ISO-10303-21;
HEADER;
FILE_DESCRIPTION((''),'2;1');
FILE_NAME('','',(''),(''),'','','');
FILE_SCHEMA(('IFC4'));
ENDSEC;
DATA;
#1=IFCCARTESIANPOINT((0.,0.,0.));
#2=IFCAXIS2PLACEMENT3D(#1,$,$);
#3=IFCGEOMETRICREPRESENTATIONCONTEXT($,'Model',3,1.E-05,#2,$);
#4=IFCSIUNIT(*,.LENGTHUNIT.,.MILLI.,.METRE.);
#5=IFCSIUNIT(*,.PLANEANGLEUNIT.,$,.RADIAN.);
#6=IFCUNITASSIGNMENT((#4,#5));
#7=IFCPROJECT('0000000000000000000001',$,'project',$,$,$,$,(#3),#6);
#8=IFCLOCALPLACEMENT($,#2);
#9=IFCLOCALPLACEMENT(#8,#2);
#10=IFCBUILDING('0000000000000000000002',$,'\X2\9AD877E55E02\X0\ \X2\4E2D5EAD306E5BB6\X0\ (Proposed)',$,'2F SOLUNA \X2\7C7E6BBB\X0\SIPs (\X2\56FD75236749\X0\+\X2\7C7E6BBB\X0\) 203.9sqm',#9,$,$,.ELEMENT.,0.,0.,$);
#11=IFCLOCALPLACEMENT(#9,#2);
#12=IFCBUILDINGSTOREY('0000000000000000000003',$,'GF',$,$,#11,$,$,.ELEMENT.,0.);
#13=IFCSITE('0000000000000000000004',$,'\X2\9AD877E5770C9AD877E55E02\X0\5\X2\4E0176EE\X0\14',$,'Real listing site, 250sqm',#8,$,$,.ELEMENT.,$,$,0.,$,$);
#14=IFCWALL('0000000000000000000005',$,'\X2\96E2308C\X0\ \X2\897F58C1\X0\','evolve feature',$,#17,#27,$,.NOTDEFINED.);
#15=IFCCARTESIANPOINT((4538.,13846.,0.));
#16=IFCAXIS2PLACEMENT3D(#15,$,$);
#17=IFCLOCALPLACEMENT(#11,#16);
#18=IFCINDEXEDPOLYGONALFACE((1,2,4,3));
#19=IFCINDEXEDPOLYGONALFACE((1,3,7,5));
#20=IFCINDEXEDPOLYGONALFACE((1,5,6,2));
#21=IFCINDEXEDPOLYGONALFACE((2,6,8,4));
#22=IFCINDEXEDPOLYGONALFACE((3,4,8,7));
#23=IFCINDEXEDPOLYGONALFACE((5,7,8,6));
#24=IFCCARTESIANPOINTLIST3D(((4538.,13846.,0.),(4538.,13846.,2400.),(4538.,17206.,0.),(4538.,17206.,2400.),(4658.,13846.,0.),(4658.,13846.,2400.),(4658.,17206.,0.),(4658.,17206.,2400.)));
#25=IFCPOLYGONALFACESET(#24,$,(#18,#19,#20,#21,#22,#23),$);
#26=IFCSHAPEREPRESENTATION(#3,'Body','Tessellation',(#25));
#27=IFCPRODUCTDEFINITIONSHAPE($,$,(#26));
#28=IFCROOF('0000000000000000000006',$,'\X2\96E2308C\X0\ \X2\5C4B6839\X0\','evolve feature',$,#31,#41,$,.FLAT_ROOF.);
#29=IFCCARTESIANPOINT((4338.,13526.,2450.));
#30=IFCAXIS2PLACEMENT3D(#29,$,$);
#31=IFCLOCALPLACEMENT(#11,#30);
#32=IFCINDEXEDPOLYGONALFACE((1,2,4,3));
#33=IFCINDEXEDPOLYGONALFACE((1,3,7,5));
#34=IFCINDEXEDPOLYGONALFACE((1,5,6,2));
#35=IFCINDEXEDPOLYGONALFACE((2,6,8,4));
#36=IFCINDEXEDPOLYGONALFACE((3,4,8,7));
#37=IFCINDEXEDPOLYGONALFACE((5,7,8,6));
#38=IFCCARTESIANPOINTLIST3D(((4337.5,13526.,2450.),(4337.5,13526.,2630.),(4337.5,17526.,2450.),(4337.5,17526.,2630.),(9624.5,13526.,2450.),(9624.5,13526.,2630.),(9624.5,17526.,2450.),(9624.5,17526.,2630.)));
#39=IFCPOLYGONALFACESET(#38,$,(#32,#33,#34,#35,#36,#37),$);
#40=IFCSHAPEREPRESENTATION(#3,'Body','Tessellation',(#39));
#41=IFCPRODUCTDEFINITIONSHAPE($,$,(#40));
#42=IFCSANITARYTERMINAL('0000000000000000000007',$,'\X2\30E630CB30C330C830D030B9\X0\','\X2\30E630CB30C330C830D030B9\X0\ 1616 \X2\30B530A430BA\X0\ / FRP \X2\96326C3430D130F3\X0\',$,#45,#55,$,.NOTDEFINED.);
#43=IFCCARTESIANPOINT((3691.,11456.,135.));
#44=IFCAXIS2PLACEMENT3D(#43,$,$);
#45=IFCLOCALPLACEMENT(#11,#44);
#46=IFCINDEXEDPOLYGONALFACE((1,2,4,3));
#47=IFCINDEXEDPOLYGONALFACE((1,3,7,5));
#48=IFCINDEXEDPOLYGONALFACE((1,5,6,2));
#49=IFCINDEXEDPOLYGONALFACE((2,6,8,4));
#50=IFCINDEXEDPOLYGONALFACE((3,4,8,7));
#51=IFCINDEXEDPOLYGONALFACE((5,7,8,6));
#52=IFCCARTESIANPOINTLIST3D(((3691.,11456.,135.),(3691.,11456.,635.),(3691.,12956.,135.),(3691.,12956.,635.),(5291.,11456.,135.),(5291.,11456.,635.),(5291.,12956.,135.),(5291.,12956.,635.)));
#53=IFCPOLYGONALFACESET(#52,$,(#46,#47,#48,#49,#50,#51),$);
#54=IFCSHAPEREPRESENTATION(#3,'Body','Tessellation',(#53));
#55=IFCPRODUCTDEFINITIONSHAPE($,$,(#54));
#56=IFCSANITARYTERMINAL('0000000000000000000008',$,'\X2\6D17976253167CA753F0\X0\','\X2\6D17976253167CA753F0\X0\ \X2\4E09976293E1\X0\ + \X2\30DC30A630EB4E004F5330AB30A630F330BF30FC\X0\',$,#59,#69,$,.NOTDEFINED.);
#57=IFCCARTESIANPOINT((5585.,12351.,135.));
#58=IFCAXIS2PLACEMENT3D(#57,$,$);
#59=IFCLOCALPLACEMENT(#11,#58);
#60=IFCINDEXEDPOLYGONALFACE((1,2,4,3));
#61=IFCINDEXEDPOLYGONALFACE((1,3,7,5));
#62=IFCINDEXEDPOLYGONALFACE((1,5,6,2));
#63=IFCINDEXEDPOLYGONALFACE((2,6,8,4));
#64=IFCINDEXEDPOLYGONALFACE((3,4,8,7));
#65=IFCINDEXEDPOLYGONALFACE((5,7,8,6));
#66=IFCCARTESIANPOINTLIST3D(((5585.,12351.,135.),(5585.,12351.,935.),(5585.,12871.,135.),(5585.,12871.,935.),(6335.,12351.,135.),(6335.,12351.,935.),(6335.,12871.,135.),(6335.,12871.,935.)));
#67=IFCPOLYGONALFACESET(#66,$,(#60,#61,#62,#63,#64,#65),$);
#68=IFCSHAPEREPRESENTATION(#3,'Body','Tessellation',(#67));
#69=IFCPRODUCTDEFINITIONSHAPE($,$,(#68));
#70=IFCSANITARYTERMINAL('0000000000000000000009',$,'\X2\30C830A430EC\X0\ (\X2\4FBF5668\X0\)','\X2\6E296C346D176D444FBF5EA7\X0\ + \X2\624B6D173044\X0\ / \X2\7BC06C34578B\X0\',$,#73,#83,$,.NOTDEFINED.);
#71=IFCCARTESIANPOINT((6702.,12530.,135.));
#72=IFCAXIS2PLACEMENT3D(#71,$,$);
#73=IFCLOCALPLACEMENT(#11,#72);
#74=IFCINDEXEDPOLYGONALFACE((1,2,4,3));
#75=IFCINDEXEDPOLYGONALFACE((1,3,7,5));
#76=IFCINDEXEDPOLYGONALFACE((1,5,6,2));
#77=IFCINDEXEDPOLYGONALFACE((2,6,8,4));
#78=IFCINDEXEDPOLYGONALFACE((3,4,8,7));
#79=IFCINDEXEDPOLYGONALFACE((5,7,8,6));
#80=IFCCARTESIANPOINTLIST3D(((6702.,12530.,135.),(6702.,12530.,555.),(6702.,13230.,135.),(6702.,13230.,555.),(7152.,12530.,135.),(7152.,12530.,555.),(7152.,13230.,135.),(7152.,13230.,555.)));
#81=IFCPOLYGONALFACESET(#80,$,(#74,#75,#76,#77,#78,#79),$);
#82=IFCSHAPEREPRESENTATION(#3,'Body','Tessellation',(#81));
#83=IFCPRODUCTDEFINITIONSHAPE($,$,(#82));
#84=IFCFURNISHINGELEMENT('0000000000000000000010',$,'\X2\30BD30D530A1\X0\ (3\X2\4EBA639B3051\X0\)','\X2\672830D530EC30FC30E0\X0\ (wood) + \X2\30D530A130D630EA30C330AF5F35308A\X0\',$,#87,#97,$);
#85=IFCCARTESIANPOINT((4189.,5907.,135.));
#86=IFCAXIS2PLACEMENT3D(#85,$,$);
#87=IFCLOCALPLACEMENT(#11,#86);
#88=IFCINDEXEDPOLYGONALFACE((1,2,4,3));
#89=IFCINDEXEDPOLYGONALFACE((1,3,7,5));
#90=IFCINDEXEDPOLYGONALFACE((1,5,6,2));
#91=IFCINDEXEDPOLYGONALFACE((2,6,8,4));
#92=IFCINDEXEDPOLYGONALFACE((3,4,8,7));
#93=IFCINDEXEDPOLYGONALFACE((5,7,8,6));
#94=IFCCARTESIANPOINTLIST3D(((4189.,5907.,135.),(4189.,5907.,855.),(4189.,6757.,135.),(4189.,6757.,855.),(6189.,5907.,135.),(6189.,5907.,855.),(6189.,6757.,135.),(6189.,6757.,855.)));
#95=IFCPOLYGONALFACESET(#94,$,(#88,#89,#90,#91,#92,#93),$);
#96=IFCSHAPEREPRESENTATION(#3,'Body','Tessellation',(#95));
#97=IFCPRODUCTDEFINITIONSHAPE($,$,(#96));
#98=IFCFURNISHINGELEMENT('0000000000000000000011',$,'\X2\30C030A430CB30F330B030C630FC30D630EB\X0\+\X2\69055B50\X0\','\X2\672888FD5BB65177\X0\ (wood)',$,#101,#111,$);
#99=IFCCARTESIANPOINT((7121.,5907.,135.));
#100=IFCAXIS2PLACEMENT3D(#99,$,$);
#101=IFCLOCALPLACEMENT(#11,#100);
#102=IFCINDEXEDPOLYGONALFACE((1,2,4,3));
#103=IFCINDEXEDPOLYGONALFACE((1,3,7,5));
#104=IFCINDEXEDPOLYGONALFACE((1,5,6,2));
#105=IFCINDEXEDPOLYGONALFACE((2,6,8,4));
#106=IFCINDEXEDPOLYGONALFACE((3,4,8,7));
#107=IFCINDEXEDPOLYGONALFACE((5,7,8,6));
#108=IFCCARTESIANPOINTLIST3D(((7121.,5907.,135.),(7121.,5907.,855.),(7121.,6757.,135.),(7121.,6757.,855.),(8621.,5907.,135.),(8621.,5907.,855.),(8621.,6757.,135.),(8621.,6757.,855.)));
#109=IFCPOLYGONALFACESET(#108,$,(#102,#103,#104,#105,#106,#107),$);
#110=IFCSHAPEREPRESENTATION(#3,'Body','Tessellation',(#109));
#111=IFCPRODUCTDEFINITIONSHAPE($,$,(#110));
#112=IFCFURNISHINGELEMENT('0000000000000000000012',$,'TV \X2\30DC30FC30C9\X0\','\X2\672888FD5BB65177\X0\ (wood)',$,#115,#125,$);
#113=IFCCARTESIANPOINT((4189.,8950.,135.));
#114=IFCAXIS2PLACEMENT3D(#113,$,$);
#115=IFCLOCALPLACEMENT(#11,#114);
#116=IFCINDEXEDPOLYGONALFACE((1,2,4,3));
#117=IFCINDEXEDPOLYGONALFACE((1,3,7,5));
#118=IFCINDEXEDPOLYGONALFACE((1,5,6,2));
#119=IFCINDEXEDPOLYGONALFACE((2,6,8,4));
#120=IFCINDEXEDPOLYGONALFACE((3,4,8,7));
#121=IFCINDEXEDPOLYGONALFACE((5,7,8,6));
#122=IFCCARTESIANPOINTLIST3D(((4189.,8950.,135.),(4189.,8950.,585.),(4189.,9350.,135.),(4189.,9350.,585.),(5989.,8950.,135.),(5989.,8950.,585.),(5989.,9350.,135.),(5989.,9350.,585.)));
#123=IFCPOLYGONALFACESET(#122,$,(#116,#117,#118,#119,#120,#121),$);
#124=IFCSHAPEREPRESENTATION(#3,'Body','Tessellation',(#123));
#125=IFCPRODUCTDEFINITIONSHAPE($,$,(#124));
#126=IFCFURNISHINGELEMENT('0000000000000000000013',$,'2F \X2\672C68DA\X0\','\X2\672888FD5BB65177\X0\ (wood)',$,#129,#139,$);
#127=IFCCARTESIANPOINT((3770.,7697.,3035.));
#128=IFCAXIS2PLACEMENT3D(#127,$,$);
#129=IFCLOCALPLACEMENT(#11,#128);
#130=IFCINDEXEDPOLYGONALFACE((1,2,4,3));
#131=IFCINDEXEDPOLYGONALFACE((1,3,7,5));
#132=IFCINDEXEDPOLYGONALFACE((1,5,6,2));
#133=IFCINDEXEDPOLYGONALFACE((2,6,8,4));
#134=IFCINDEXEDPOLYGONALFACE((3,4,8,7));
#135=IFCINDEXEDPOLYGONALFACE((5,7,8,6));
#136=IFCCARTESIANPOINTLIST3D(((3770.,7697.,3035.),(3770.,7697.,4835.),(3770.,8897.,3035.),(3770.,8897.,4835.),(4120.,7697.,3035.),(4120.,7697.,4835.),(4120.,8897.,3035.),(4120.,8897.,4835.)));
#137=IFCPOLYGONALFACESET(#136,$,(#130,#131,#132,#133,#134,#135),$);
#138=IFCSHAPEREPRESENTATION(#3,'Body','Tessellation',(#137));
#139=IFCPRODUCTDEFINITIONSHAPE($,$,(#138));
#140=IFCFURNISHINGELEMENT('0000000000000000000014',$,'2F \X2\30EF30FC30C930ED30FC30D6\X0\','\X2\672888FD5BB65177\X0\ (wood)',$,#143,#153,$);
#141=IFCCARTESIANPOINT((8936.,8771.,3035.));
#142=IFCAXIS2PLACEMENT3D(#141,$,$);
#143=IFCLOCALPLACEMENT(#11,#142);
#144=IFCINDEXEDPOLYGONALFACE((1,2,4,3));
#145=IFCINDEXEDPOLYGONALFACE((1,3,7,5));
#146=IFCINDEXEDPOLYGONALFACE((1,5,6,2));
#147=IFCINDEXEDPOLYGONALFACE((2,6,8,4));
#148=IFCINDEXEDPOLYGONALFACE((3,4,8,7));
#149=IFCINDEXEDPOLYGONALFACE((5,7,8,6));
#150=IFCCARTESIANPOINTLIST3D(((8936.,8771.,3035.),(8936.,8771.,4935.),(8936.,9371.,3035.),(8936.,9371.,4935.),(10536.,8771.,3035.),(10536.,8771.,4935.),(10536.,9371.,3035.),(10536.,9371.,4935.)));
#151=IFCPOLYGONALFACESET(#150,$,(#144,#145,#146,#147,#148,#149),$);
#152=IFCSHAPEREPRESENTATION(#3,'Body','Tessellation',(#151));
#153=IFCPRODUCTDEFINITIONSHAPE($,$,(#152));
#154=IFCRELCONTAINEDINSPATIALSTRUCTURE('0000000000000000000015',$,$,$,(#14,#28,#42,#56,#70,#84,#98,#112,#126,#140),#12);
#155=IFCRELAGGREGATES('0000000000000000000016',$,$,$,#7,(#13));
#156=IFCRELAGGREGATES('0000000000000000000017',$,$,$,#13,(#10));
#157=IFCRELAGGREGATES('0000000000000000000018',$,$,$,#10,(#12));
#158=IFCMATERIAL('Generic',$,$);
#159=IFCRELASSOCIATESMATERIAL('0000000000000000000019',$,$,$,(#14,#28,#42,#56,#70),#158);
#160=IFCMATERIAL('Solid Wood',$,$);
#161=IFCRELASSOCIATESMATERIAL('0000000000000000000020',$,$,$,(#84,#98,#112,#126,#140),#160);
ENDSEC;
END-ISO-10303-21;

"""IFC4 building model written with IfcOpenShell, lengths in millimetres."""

from ifc_helpers import new_model, si_unit, frame, frame_2d, origin, place, context, project, spatial, rectangle, extrude, material, element, save


model = new_model("IFC4")

# Units and contexts
model_context = context("Model", 3, precision=1e-05, world=origin())
ifc_project = project(units=[si_unit("LENGTHUNIT", "METRE", prefix="MILLI"), si_unit("PLANEANGLEUNIT", "RADIAN")], contexts=[model_context])

# Site, building, storey
site_placement = place(None, origin())
site = spatial("IfcSite", under=ifc_project, at=site_placement, Name="高知県高知市5丁目14", ObjectType="Real listing site, 250sqm", CompositionType="ELEMENT", RefElevation=0.0)
building_placement = place(site_placement, origin())
building = spatial("IfcBuilding", under=site, at=building_placement, Name="高知市 中庭の家 (Proposed)", ObjectType="2F SOLUNA 籾殻SIPs (国産杉+籾殻) 203.9sqm", CompositionType="ELEMENT", ElevationOfRefHeight=0.0, ElevationOfTerrain=0.0)
storey_placement = place(building_placement, origin())
storey = spatial("IfcBuildingStorey", under=building, at=storey_placement, Name="GF", CompositionType="ELEMENT", Elevation=0.0)

# Shared definitions
ifc_material_1 = material(Name="Generic")

# Shared definitions
ifc_material_2 = material(Name="Solid Wood")

# Wall
wall_1_placement = place(storey_placement, frame((4538.0, 13846.0, 0.0)))
element("IfcWall", 1, at=wall_1_placement, inside=storey, material=ifc_material_1, Name="離れ 西壁", Description="evolve feature", PredefinedType="NOTDEFINED", context=model_context, shape_type="SweptSolid", body=[
    extrude(rectangle(XDim=120.0, YDim=3360.0, at=frame_2d((60.0, 1680.0))), frame((4538.0, 13846.0, 0.0)), (0.0, 0.0, 1.0), 2400.0),
])

# Roof
roof_1_placement = place(storey_placement, frame((4338.0, 13526.0, 2450.0)))
element("IfcRoof", 2, at=roof_1_placement, inside=storey, material=ifc_material_1, Name="離れ 屋根", Description="evolve feature", PredefinedType="FLAT_ROOF", context=model_context, shape_type="SweptSolid", body=[
    extrude(rectangle(XDim=5287.0, YDim=4000.0, at=frame_2d((2643.0, 2000.0))), frame((4338.0, 13526.0, 2450.0)), (0.0, 0.0, 1.0), 180.0),
])

# Sanitary terminals
sanitary_terminal_1_placement = place(storey_placement, frame((3691.0, 11456.0, 135.0)))
element("IfcSanitaryTerminal", 3, at=sanitary_terminal_1_placement, inside=storey, material=ifc_material_1, Name="ユニットバス", Description="ユニットバス 1616 サイズ / FRP 防水パン", PredefinedType="NOTDEFINED", context=model_context, shape_type="SweptSolid", body=[
    extrude(rectangle(XDim=1600.0, YDim=1500.0, at=frame_2d((800.0, 750.0))), frame((3691.0, 11456.0, 135.0)), (0.0, 0.0, 1.0), 500.0),
])
sanitary_terminal_2_placement = place(storey_placement, frame((5585.0, 12351.0, 135.0)))
element("IfcSanitaryTerminal", 4, at=sanitary_terminal_2_placement, inside=storey, material=ifc_material_1, Name="洗面化粧台", Description="洗面化粧台 三面鏡 + ボウル一体カウンター", PredefinedType="NOTDEFINED", context=model_context, shape_type="SweptSolid", body=[
    extrude(rectangle(XDim=750.0, YDim=520.0, at=frame_2d((375.0, 260.0))), frame((5585.0, 12351.0, 135.0)), (0.0, 0.0, 1.0), 800.0),
])
sanitary_terminal_3_placement = place(storey_placement, frame((6702.0, 12530.0, 135.0)))
element("IfcSanitaryTerminal", 5, at=sanitary_terminal_3_placement, inside=storey, material=ifc_material_1, Name="トイレ (便器)", Description="温水洗浄便座 + 手洗い / 節水型", PredefinedType="NOTDEFINED", context=model_context, shape_type="SweptSolid", body=[
    extrude(rectangle(XDim=450.0, YDim=700.0, at=frame_2d((225.0, 350.0))), frame((6702.0, 12530.0, 135.0)), (0.0, 0.0, 1.0), 420.0),
])

# Furnishing elements
furnishing_1_placement = place(storey_placement, frame((4189.0, 5907.0, 135.0)))
element("IfcFurnishingElement", 6, at=furnishing_1_placement, inside=storey, material=ifc_material_2, Name="ソファ (3人掛け)", Description="木フレーム (wood) + ファブリック張り", context=model_context, shape_type="SweptSolid", body=[
    extrude(rectangle(XDim=2000.0, YDim=850.0, at=frame_2d((1000.0, 425.0))), frame((4189.0, 5907.0, 135.0)), (0.0, 0.0, 1.0), 720.0),
])
furnishing_2_placement = place(storey_placement, frame((7121.0, 5907.0, 135.0)))
element("IfcFurnishingElement", 7, at=furnishing_2_placement, inside=storey, material=ifc_material_2, Name="ダイニングテーブル+椅子", Description="木製家具 (wood)", context=model_context, shape_type="SweptSolid", body=[
    extrude(rectangle(XDim=1500.0, YDim=850.0, at=frame_2d((750.0, 425.0))), frame((7121.0, 5907.0, 135.0)), (0.0, 0.0, 1.0), 720.0),
])
furnishing_3_placement = place(storey_placement, frame((4189.0, 8950.0, 135.0)))
element("IfcFurnishingElement", 8, at=furnishing_3_placement, inside=storey, material=ifc_material_2, Name="TV ボード", Description="木製家具 (wood)", context=model_context, shape_type="SweptSolid", body=[
    extrude(rectangle(XDim=1800.0, YDim=400.0, at=frame_2d((900.0, 200.0))), frame((4189.0, 8950.0, 135.0)), (0.0, 0.0, 1.0), 450.0),
])
furnishing_4_placement = place(storey_placement, frame((3770.0, 7697.0, 3035.0)))
element("IfcFurnishingElement", 9, at=furnishing_4_placement, inside=storey, material=ifc_material_2, Name="2F 本棚", Description="木製家具 (wood)", context=model_context, shape_type="SweptSolid", body=[
    extrude(rectangle(XDim=350.0, YDim=1200.0, at=frame_2d((175.0, 600.0))), frame((3770.0, 7697.0, 3035.0)), (0.0, 0.0, 1.0), 1800.0),
])
furnishing_5_placement = place(storey_placement, frame((8936.0, 8771.0, 3035.0)))
element("IfcFurnishingElement", 10, at=furnishing_5_placement, inside=storey, material=ifc_material_2, Name="2F ワードローブ", Description="木製家具 (wood)", context=model_context, shape_type="SweptSolid", body=[
    extrude(rectangle(XDim=1600.0, YDim=600.0, at=frame_2d((800.0, 300.0))), frame((8936.0, 8771.0, 3035.0)), (0.0, 0.0, 1.0), 1900.0),
])

save(model, "model.ifc")
